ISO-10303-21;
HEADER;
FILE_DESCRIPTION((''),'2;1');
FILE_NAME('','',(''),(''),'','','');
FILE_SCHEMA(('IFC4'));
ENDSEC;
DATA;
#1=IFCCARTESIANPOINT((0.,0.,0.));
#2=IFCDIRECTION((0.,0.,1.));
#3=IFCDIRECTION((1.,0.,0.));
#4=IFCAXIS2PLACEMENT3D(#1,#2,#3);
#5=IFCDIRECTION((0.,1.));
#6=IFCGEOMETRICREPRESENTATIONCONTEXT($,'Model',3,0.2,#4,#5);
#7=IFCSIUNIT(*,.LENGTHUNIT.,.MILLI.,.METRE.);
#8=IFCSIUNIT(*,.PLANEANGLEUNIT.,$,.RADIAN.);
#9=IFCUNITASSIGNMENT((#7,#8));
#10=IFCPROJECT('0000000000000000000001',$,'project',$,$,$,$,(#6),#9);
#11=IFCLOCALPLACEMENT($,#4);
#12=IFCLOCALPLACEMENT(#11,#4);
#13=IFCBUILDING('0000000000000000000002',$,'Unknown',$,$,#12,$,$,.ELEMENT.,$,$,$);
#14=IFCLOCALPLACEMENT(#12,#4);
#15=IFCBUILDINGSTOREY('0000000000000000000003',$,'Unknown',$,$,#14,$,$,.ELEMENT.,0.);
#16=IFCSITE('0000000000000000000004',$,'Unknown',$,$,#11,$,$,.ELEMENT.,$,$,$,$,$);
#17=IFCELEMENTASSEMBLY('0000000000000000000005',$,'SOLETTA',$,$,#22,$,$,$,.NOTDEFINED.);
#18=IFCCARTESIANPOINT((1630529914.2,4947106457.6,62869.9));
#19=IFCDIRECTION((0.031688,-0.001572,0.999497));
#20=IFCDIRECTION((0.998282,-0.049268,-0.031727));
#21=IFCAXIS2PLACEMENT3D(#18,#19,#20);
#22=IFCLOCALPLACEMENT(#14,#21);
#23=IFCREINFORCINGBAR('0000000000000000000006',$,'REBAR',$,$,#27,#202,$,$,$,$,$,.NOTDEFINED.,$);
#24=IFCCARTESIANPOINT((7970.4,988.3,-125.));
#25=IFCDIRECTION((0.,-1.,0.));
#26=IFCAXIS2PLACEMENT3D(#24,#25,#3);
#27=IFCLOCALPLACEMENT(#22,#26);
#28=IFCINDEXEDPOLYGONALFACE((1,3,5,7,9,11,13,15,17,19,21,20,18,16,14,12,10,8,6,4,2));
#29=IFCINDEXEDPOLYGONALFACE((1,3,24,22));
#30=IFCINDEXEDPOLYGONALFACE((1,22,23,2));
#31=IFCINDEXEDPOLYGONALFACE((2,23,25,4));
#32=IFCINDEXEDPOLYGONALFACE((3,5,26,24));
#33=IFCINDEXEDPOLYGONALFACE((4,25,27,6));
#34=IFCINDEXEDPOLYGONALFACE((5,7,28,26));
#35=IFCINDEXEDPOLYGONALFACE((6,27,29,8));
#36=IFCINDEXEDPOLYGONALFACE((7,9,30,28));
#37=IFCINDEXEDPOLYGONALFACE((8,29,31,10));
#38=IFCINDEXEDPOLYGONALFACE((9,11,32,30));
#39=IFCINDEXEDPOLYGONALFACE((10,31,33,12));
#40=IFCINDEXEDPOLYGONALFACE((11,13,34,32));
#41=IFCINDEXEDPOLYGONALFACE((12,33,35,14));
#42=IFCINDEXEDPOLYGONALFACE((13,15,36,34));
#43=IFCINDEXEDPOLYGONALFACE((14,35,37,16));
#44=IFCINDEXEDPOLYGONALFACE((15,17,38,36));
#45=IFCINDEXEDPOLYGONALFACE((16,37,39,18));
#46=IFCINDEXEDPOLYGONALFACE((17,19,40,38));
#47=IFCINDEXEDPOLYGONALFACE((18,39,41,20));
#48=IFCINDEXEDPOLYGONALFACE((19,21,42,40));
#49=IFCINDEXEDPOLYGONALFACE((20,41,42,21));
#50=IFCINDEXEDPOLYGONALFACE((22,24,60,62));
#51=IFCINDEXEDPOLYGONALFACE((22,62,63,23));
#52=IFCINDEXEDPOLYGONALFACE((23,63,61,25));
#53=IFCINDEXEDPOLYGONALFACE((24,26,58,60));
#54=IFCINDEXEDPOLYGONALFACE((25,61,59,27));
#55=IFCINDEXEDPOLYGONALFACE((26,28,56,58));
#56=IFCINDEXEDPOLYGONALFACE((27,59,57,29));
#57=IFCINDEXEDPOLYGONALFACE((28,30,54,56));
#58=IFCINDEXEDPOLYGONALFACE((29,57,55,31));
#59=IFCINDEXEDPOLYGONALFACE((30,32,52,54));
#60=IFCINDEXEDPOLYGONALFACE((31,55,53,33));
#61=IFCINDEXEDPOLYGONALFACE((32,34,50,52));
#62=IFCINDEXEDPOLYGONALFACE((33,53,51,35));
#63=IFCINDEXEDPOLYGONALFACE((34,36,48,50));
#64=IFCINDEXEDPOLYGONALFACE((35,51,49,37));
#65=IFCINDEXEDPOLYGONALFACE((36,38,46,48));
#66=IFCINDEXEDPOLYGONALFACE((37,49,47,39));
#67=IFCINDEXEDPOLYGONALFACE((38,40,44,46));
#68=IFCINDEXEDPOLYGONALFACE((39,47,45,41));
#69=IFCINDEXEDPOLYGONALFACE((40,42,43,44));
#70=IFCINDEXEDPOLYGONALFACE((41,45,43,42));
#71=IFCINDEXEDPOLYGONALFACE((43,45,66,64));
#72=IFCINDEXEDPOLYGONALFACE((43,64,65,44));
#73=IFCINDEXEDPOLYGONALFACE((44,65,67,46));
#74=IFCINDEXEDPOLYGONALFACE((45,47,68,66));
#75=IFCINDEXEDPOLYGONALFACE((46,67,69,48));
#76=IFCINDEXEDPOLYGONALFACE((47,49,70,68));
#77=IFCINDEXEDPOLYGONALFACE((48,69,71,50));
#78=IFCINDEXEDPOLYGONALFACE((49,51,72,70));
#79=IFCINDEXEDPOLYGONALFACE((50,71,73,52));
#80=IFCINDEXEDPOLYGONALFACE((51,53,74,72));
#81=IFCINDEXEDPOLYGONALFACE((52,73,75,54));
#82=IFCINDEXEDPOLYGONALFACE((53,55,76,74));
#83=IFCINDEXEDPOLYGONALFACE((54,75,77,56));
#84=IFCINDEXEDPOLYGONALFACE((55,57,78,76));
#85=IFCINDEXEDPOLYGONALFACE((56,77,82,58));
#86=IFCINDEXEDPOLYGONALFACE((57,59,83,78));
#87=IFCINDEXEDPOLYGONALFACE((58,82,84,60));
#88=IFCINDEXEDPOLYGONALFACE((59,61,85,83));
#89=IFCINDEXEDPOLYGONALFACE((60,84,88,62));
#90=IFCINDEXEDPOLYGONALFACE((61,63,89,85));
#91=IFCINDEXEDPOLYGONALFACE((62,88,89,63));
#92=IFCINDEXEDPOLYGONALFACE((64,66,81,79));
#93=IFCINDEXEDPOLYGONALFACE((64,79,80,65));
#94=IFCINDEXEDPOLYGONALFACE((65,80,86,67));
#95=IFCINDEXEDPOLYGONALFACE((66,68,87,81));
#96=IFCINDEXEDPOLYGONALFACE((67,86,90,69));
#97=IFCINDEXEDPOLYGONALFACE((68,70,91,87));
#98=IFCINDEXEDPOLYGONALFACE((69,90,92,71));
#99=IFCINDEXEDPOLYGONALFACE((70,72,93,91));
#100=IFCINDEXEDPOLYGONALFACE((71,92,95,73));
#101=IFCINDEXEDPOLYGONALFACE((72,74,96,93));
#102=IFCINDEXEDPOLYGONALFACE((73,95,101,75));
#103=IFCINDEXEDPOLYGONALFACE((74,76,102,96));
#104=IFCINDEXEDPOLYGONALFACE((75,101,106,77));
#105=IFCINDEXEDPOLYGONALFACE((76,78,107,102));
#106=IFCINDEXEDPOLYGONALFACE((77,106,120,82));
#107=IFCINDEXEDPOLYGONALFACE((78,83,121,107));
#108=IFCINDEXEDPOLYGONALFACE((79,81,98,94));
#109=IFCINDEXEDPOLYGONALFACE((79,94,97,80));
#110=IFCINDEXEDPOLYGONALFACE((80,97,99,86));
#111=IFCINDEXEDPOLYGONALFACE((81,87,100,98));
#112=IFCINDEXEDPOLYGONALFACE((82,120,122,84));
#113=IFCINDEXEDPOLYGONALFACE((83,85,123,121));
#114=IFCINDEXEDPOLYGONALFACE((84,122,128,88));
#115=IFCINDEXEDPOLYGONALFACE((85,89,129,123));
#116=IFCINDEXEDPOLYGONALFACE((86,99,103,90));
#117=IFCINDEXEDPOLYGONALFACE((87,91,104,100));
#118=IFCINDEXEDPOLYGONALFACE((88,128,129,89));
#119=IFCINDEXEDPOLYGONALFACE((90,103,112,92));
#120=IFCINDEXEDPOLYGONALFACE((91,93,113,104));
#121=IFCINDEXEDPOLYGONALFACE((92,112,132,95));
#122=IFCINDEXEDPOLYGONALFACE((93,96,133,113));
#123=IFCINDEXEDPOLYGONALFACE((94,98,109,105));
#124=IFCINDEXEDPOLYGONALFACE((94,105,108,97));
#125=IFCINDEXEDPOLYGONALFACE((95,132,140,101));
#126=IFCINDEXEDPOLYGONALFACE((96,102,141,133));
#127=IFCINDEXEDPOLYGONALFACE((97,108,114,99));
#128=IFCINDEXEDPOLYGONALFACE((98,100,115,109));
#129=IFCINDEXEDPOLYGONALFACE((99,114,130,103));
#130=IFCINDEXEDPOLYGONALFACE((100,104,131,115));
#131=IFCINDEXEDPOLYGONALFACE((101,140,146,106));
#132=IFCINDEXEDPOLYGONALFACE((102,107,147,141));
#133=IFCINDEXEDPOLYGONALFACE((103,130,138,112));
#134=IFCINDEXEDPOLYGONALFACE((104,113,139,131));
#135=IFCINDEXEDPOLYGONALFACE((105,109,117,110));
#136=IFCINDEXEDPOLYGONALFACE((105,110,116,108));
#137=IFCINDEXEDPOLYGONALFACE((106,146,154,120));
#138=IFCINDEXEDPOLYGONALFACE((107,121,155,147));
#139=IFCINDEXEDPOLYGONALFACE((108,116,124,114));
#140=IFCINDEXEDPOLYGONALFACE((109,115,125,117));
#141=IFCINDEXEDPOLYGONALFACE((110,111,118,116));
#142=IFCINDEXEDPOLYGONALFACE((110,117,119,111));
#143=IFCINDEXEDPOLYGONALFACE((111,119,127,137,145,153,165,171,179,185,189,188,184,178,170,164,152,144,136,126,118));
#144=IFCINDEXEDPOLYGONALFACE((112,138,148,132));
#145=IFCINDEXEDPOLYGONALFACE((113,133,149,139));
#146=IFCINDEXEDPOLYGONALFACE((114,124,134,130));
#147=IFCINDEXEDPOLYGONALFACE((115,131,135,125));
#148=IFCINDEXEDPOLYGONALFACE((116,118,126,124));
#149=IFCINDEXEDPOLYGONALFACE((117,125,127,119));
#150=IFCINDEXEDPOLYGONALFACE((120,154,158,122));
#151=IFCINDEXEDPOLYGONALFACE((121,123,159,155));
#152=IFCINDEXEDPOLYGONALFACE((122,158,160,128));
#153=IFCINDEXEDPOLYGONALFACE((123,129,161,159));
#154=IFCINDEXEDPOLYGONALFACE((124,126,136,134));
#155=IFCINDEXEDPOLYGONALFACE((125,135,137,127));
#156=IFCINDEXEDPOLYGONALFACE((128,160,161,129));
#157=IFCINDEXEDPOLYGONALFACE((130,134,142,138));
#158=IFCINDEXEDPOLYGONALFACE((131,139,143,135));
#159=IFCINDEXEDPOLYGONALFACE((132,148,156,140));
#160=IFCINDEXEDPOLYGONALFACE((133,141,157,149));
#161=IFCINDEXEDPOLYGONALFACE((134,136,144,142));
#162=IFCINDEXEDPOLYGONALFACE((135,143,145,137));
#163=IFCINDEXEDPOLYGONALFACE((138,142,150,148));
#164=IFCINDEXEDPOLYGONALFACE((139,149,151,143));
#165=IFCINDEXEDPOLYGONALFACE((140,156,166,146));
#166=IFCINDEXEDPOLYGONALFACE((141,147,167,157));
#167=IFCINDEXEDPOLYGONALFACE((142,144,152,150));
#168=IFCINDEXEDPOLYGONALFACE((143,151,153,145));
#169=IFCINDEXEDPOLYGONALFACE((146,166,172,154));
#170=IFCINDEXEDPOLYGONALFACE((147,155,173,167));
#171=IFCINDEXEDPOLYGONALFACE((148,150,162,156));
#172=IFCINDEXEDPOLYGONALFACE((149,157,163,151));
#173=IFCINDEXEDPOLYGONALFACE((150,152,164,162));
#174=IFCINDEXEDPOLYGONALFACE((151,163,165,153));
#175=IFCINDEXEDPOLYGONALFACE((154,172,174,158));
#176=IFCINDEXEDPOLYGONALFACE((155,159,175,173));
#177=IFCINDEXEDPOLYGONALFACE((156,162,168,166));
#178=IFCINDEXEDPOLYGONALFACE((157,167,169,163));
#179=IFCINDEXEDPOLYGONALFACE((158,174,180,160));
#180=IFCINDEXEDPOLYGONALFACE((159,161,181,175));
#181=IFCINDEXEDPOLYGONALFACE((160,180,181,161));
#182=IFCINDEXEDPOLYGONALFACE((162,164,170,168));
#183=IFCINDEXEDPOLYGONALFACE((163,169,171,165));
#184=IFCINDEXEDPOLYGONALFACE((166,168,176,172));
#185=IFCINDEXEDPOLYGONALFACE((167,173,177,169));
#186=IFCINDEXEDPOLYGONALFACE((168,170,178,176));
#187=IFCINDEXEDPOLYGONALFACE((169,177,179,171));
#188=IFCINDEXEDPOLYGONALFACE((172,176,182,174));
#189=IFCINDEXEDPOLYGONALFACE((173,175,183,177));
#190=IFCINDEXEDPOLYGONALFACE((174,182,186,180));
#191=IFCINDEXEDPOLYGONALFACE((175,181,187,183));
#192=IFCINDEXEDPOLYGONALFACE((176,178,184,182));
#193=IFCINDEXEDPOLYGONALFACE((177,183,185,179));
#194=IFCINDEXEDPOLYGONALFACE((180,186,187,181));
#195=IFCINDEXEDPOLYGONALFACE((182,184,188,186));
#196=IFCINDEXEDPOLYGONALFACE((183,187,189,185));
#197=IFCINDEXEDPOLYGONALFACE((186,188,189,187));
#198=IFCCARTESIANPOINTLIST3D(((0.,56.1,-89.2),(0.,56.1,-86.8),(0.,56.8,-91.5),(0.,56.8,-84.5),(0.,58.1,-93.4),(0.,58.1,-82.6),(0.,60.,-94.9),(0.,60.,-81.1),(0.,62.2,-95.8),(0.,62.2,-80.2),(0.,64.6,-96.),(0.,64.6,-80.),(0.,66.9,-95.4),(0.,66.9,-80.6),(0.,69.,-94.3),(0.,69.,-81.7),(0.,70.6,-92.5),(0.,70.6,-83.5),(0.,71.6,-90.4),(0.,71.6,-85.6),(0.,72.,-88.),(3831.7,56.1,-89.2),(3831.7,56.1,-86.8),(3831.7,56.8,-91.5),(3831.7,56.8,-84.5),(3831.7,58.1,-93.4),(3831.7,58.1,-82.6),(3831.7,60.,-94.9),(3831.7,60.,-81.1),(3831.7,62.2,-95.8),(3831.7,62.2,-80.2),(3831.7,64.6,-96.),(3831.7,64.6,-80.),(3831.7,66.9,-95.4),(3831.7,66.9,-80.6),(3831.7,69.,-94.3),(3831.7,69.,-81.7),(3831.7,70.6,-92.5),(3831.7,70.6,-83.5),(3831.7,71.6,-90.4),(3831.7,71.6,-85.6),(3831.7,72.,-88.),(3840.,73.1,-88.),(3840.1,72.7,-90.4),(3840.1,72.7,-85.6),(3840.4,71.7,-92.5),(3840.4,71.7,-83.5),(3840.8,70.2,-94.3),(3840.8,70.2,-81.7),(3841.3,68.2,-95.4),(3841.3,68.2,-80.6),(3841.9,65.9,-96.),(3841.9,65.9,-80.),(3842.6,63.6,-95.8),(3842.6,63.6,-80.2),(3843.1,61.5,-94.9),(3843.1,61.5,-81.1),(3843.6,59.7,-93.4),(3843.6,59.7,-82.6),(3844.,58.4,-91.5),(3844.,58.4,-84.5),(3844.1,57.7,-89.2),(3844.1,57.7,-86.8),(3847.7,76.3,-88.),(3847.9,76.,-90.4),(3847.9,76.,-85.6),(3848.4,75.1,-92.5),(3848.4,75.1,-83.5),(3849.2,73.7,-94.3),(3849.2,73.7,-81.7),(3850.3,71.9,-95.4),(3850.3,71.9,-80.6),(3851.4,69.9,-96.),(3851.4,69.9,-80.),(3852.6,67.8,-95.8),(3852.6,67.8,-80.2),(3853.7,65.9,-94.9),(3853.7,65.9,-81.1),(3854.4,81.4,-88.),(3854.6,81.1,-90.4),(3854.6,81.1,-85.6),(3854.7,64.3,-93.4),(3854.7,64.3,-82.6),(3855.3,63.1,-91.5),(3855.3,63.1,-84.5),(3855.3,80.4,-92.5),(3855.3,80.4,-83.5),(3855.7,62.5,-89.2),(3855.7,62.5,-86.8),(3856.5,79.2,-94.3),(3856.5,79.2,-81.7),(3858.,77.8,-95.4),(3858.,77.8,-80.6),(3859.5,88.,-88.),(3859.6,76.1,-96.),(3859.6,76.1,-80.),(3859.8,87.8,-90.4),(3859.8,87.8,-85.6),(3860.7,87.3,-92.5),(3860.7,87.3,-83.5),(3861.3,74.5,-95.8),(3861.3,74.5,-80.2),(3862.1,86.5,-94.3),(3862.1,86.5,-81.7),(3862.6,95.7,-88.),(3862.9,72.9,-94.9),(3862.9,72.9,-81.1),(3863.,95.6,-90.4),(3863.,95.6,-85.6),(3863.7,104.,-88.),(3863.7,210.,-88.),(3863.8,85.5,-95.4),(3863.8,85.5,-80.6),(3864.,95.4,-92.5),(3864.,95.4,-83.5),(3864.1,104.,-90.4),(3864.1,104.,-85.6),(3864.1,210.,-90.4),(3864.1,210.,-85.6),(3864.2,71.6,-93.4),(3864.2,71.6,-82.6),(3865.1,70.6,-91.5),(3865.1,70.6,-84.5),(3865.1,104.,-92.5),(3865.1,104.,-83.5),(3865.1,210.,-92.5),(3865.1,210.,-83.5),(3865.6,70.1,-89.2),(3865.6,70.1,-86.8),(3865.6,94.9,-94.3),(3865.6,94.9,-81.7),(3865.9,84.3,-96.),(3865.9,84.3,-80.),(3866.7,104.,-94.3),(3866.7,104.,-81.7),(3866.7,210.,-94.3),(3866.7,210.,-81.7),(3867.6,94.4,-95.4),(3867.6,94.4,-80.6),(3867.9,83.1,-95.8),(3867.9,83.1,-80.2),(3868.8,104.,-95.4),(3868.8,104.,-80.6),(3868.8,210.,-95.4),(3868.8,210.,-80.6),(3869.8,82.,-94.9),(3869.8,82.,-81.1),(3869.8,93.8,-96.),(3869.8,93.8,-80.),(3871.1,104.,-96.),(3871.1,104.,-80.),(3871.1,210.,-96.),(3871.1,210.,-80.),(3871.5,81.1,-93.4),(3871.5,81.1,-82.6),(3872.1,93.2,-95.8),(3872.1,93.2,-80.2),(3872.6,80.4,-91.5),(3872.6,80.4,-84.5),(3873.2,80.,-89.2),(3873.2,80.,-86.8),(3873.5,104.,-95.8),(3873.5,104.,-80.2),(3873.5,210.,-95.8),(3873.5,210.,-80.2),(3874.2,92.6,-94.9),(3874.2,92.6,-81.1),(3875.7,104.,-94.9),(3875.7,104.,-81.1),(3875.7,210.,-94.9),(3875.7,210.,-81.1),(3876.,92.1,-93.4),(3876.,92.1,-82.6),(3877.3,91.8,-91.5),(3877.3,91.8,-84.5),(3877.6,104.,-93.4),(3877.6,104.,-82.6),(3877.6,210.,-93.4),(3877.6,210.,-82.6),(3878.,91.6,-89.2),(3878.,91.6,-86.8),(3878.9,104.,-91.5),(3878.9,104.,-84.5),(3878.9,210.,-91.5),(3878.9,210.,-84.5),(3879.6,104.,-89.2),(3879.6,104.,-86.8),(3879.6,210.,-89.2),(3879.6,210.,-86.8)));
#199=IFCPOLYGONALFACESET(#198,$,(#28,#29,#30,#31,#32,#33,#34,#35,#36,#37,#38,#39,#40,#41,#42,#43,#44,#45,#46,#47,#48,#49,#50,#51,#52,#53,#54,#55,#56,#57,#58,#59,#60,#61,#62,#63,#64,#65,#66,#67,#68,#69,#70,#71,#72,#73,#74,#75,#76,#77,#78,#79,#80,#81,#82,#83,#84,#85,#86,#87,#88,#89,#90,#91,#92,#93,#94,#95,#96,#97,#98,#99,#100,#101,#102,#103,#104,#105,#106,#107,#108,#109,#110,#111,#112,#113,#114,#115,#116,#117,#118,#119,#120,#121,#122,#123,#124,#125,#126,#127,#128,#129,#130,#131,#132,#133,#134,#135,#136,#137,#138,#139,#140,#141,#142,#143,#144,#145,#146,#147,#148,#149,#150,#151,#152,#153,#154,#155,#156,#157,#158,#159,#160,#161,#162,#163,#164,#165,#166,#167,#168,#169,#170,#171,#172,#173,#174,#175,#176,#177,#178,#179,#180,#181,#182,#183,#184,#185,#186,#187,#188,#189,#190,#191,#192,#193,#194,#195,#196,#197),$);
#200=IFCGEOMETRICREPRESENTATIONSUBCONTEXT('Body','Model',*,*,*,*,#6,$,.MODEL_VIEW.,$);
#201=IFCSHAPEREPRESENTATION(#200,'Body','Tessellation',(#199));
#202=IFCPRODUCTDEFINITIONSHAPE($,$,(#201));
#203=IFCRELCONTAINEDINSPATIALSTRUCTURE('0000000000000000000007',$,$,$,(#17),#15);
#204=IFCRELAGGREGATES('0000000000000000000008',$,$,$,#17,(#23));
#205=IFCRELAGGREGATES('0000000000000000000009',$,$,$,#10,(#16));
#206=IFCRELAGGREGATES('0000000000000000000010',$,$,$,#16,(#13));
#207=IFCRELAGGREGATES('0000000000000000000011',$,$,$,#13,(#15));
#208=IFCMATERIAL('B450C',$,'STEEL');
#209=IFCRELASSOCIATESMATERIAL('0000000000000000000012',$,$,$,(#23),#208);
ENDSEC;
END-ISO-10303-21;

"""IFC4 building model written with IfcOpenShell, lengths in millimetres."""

from ifc_helpers import new_model, entity, si_unit, direction, frame, origin_with_axes, place, context, subcontext, project, spatial, material, element, aggregate, save


model = new_model("IFC4")

# Units and contexts
model_context = context("Model", 3, precision=0.2, world=origin_with_axes(), true_north=direction((0.0, 1.0)))
body_context = subcontext(model_context, "Body", "Model", "MODEL_VIEW")
ifc_project = project(units=[si_unit("LENGTHUNIT", "METRE", prefix="MILLI"), si_unit("PLANEANGLEUNIT", "RADIAN")], contexts=[model_context])

# Site, building, storey
site_placement = place(None, origin_with_axes())
site = spatial("IfcSite", under=ifc_project, at=site_placement, Name="Unknown", CompositionType="ELEMENT")
building_placement = place(site_placement, origin_with_axes())
building = spatial("IfcBuilding", under=site, at=building_placement, Name="Unknown", CompositionType="ELEMENT")
storey_placement = place(building_placement, origin_with_axes())
storey = spatial("IfcBuildingStorey", under=building, at=storey_placement, Name="Unknown", CompositionType="ELEMENT", Elevation=0.0)

# Element assembly, reinforcing bar
ifc_material = material(Name="B450C", Category="STEEL")
assembly_1_placement = place(storey_placement, frame((1630529914.2, 4947106457.6, 62869.9), z_axis=(0.031688, -0.001572, 0.999497), x_axis=(0.998282, -0.049268, -0.031727)))
assembly_1 = element("IfcElementAssembly", 1, at=assembly_1_placement, inside=storey, Name="SOLETTA", PredefinedType="NOTDEFINED")
reinforcing_bar_1_placement = place(assembly_1_placement, frame((7970.4, 988.3, -125.0), z_axis=(0.0, -1.0, 0.0), x_axis=(1.0, 0.0, 0.0)))
reinforcing_bar_1 = element("IfcReinforcingBar", 2, at=reinforcing_bar_1_placement, material=ifc_material, Name="REBAR", PredefinedType="NOTDEFINED", context=body_context, shape_type="AdvancedSweptSolid", body=[
    entity("IfcSweptDiskSolid", entity("IfcIndexedPolyCurve", entity("IfcCartesianPointList3D", [[0.0, 64.0, -88.0], [3831.7, 64.0, -88.0], [3860.0, 75.7, -88.0], [3871.7, 104.0, -88.0], [3871.7, 210.0, -88.0]]), [entity("IfcLineIndex", [1, 2]), entity("IfcArcIndex", [2, 3, 4]), entity("IfcLineIndex", [4, 5])]), 8.0),
])
aggregate(assembly_1, [reinforcing_bar_1])

save(model, "model.ifc")
